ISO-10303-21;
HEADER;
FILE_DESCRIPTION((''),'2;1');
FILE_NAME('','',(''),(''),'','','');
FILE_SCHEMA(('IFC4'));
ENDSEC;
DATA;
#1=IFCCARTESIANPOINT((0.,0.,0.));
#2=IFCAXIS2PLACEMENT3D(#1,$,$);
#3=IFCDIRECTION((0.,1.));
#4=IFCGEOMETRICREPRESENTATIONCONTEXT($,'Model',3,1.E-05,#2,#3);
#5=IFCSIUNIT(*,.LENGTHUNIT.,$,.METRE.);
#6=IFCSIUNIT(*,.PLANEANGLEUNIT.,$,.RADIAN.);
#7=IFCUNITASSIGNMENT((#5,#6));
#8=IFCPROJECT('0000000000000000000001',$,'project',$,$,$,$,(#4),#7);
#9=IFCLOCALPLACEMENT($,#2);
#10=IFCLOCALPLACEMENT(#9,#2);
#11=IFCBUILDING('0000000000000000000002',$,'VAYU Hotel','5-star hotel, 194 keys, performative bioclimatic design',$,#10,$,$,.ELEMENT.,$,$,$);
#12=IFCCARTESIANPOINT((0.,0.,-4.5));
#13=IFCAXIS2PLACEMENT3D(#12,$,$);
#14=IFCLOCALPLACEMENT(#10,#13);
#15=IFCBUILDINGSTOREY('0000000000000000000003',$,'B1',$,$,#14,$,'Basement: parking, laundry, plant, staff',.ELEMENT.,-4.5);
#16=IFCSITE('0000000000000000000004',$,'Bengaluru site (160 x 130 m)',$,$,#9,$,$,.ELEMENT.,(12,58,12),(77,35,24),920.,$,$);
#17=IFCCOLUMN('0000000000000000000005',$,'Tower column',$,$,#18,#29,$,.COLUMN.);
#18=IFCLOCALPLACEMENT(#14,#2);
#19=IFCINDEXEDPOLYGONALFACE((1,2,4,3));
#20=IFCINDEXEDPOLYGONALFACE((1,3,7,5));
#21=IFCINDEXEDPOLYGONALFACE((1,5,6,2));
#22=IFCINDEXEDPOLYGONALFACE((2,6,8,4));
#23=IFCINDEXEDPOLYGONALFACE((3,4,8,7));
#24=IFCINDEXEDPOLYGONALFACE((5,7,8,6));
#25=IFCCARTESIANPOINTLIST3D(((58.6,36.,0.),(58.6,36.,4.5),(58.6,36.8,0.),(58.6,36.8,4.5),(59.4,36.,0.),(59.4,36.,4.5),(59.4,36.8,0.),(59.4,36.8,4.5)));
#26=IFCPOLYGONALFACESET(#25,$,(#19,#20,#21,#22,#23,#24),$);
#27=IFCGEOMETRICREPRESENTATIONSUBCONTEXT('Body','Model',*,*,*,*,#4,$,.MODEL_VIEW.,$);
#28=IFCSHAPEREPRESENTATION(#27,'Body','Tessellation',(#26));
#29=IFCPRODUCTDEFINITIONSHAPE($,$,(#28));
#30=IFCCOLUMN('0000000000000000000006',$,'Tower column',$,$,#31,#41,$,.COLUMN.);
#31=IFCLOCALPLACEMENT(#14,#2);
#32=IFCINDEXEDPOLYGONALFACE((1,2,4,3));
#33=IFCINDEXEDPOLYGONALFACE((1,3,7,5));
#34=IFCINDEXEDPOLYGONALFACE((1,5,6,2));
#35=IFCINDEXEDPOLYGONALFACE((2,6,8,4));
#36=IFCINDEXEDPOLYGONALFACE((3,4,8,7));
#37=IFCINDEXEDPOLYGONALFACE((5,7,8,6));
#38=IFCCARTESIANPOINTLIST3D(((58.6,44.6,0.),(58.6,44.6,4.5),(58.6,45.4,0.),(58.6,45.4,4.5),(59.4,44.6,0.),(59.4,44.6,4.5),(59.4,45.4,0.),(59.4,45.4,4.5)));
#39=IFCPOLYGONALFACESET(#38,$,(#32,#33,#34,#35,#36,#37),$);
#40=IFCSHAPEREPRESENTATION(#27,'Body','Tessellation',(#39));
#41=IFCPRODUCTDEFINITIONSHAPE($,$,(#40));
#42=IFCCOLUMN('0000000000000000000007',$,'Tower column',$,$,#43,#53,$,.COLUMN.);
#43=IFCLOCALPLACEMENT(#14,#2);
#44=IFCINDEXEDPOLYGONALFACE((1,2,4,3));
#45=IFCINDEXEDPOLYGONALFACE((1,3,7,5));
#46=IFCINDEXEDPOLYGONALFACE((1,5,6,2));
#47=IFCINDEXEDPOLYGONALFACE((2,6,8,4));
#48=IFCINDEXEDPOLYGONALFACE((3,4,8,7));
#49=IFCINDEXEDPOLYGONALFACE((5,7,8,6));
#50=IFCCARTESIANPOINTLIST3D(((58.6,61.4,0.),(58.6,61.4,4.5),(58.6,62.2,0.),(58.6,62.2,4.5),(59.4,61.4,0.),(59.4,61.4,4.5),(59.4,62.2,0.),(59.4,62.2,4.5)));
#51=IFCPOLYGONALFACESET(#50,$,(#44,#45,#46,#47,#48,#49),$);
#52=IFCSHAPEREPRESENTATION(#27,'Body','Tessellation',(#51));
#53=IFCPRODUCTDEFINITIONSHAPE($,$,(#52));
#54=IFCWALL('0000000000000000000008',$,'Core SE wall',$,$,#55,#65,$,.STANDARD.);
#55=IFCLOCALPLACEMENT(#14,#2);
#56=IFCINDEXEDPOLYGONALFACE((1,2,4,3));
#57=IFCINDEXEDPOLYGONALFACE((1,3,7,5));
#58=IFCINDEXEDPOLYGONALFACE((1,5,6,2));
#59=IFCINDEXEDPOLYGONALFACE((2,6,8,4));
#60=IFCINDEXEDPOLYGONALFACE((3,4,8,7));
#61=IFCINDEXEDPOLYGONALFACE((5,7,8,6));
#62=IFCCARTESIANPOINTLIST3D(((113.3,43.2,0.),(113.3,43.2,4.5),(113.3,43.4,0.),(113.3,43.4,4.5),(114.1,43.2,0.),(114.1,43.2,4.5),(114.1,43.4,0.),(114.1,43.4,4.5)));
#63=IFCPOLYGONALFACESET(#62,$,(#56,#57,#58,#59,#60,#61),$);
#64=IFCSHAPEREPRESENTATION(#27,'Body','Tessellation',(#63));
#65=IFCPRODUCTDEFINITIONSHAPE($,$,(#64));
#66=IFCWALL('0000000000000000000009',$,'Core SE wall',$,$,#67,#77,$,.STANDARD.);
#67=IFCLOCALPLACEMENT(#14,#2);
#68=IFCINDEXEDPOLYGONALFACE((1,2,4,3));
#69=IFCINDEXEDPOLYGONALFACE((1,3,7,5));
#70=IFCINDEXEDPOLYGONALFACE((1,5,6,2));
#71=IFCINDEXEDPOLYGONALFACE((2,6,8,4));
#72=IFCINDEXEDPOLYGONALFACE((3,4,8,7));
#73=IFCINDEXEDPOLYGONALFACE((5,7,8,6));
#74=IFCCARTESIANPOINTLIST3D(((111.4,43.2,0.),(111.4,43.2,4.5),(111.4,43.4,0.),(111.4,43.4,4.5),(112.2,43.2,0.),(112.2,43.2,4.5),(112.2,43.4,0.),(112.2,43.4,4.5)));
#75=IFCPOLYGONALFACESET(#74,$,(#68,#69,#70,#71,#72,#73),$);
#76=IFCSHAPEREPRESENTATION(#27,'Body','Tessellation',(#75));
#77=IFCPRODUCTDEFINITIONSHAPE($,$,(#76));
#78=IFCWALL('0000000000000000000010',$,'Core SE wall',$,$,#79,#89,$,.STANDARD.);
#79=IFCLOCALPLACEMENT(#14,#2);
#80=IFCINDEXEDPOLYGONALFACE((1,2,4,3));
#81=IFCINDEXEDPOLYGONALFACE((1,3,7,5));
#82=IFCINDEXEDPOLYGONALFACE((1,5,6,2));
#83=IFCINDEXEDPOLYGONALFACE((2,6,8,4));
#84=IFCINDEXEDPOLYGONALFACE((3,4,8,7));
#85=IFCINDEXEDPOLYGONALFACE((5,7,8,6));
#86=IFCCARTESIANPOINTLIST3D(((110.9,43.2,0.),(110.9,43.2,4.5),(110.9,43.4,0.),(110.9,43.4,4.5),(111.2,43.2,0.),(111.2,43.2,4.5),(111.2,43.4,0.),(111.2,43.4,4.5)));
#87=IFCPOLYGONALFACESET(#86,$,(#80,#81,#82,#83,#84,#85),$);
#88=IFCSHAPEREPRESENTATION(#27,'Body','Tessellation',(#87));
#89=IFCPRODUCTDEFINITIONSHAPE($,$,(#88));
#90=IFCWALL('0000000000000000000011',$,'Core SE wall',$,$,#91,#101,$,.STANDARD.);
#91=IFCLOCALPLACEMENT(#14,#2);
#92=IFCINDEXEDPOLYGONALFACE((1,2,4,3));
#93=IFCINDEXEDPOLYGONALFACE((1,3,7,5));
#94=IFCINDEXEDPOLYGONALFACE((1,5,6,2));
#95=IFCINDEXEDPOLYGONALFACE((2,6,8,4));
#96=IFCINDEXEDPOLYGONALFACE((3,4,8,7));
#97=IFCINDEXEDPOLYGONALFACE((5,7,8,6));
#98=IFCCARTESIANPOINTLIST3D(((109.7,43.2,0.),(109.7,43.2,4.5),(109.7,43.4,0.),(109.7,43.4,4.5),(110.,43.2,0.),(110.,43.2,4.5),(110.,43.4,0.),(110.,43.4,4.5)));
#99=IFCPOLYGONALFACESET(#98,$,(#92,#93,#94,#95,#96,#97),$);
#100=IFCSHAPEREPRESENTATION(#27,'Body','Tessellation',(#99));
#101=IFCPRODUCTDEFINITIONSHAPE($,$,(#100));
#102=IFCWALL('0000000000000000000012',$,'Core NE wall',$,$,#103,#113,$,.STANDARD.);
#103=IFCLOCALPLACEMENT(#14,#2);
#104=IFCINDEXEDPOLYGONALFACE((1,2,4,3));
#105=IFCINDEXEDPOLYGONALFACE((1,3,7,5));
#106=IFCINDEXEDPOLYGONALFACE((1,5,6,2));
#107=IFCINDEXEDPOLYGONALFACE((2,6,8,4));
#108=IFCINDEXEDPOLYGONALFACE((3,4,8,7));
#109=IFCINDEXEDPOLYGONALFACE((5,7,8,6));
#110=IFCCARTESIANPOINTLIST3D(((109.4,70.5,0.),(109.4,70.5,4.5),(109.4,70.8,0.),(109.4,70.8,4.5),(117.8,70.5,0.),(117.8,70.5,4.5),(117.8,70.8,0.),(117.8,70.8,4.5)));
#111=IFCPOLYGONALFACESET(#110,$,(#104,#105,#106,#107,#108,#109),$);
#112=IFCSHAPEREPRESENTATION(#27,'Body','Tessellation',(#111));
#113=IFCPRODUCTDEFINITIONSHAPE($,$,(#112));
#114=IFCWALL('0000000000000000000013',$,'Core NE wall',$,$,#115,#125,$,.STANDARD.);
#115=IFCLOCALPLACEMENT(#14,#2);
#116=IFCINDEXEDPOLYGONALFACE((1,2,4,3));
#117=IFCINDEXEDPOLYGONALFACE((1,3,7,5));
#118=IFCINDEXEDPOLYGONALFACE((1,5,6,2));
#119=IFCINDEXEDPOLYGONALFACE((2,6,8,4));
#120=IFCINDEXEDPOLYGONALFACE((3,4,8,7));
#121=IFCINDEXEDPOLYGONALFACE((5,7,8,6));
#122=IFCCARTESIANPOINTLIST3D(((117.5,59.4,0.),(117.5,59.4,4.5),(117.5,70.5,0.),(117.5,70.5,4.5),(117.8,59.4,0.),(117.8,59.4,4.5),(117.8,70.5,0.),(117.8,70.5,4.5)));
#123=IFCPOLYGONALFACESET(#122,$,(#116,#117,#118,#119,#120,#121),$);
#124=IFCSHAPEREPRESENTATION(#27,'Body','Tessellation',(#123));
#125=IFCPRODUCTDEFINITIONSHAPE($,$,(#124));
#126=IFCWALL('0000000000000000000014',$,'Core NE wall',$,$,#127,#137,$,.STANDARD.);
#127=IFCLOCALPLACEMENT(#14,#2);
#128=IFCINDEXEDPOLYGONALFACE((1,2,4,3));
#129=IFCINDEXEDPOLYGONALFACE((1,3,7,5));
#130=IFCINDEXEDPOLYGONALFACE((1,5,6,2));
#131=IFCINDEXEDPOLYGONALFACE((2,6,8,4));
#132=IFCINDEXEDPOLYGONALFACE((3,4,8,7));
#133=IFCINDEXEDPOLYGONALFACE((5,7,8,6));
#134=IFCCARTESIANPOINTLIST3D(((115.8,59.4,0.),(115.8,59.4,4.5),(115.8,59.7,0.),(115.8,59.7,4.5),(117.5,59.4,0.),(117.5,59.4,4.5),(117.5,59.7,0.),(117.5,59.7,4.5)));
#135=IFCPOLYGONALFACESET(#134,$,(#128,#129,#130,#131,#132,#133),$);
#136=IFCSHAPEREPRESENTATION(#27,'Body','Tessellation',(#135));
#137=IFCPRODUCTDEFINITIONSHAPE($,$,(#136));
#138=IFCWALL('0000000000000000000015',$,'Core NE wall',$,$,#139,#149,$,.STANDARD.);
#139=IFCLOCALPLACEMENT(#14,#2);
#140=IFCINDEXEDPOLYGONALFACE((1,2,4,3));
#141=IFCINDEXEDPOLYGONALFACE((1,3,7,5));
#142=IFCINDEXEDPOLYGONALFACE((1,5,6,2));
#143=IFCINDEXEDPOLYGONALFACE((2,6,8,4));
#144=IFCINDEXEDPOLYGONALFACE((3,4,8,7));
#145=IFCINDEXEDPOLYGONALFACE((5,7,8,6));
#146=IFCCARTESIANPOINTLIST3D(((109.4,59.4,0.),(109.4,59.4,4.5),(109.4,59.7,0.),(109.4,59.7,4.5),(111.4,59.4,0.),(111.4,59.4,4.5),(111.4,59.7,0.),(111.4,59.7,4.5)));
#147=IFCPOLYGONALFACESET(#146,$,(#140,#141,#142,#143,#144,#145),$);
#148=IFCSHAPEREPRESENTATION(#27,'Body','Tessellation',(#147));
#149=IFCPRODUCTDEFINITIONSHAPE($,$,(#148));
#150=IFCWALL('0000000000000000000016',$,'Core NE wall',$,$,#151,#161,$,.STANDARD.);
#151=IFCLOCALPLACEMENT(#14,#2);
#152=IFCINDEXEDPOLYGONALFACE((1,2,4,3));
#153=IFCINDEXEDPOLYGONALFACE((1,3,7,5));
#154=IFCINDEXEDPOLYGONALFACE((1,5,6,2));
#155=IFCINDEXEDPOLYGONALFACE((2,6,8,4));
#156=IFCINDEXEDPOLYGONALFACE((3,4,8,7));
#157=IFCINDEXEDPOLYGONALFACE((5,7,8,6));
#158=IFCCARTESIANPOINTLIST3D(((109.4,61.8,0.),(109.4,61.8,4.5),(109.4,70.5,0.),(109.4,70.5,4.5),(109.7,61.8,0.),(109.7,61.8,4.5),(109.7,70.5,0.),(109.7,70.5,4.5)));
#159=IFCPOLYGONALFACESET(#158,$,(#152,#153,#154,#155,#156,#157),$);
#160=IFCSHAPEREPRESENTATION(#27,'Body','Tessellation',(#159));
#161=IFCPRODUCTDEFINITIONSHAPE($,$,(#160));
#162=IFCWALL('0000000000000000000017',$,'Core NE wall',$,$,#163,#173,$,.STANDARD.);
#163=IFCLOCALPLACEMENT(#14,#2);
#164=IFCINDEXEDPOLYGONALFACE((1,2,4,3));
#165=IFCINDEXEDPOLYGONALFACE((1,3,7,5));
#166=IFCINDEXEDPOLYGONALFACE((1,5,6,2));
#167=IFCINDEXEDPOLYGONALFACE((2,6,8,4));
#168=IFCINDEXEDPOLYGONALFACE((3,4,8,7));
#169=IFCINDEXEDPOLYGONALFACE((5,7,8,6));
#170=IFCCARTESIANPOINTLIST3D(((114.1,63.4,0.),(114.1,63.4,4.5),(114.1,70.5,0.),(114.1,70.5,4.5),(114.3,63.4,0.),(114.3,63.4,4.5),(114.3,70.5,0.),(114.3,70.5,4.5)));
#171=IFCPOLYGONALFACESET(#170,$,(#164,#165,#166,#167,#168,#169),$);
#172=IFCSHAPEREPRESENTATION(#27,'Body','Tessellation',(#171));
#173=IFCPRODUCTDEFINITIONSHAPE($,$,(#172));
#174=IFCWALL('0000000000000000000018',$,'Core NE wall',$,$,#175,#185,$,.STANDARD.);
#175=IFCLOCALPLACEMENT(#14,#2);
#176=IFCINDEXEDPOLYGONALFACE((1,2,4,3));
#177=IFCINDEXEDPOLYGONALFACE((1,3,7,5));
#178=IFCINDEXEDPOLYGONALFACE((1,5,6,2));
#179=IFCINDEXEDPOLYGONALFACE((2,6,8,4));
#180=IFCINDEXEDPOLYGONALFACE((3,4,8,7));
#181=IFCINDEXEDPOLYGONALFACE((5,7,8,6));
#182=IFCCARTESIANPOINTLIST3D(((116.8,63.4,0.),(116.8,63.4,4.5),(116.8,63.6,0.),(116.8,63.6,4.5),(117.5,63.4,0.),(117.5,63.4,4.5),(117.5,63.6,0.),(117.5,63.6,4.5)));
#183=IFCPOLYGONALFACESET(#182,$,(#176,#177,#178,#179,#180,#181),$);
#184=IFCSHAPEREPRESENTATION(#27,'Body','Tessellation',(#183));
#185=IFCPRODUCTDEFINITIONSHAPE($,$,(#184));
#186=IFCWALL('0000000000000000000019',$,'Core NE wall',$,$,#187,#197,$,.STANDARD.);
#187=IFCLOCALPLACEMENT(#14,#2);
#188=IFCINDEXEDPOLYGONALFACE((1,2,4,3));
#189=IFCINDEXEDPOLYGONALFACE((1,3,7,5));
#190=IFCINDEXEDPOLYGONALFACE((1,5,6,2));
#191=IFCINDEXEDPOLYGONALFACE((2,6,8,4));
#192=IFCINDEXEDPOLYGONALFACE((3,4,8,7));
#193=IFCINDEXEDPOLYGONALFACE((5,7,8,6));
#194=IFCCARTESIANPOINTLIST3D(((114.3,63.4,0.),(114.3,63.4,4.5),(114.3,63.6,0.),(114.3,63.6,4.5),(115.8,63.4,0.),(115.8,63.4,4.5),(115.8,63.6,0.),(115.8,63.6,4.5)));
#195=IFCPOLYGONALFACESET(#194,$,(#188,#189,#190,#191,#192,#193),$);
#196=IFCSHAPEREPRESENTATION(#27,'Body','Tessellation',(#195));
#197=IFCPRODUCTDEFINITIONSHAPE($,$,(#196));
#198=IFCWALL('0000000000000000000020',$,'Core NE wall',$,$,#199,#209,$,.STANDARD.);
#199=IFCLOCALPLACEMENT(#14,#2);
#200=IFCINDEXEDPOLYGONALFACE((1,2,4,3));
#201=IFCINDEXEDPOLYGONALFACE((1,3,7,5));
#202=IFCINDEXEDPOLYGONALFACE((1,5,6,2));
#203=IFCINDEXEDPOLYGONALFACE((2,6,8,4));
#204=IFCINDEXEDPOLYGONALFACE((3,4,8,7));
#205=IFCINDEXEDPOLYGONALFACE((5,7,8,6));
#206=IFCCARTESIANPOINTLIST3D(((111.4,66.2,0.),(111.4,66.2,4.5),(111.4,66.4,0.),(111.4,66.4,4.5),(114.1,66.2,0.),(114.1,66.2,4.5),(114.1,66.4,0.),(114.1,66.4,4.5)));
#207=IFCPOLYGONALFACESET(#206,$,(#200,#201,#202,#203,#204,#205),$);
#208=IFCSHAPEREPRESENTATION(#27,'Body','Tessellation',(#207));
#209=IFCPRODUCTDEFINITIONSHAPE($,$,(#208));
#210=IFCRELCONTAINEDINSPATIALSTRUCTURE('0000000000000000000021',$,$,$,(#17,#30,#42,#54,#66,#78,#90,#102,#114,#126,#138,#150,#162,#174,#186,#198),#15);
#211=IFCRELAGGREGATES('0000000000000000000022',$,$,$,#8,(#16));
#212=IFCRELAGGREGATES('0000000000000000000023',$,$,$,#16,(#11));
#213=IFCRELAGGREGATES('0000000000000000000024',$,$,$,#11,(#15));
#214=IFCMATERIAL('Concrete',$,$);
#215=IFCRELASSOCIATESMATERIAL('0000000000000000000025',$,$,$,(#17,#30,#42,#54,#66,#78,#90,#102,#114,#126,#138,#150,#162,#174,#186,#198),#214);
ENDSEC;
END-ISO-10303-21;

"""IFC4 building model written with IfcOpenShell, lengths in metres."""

from ifc_helpers import new_model, si_unit, direction, frame, origin, place, context, subcontext, project, spatial, polyline, outline, extrude, material, element, save


model = new_model("IFC4")

# Units and contexts
model_context = context("Model", 3, precision=1e-05, world=origin(), true_north=direction((0.0, 1.0)))
body_context = subcontext(model_context, "Body", "Model", "MODEL_VIEW")
ifc_project = project(units=[si_unit("LENGTHUNIT", "METRE"), si_unit("PLANEANGLEUNIT", "RADIAN")], contexts=[model_context])

# Site, building, storey
site_placement = place(None, origin())
site = spatial("IfcSite", under=ifc_project, at=site_placement, Name="Bengaluru site (160 x 130 m)", CompositionType="ELEMENT", RefLatitude=(12, 58, 12), RefLongitude=(77, 35, 24), RefElevation=920.0)
building_placement = place(site_placement, origin())
building = spatial("IfcBuilding", under=site, at=building_placement, Name="VAYU Hotel", Description="5-star hotel, 194 keys, performative bioclimatic design", CompositionType="ELEMENT")
storey_placement = place(building_placement, frame((0.0, 0.0, -4.5)))
storey = spatial("IfcBuildingStorey", under=building, at=storey_placement, Name="B1", LongName="Basement: parking, laundry, plant, staff", CompositionType="ELEMENT", Elevation=-4.5)

# Columns
ifc_material = material(Name="Concrete")
column_1_placement = place(storey_placement, origin())
element("IfcColumn", 1, at=column_1_placement, inside=storey, material=ifc_material, Name="Tower column", PredefinedType="COLUMN", context=body_context, shape_type="SweptSolid", body=[
    extrude(outline(polyline([(58.6, 36.0), (59.4, 36.0), (59.4, 36.8), (58.6, 36.8), (58.6, 36.0)])), origin(), (0.0, 0.0, 1.0), 4.5),
])
column_2_placement = place(storey_placement, origin())
element("IfcColumn", 2, at=column_2_placement, inside=storey, material=ifc_material, Name="Tower column", PredefinedType="COLUMN", context=body_context, shape_type="SweptSolid", body=[
    extrude(outline(polyline([(58.6, 44.6), (59.4, 44.6), (59.4, 45.4), (58.6, 45.4), (58.6, 44.6)])), origin(), (0.0, 0.0, 1.0), 4.5),
])
column_3_placement = place(storey_placement, origin())
element("IfcColumn", 3, at=column_3_placement, inside=storey, material=ifc_material, Name="Tower column", PredefinedType="COLUMN", context=body_context, shape_type="SweptSolid", body=[
    extrude(outline(polyline([(58.6, 61.4), (59.4, 61.4), (59.4, 62.2), (58.6, 62.2), (58.6, 61.4)])), origin(), (0.0, 0.0, 1.0), 4.5),
])

# Walls
wall_1_placement = place(storey_placement, origin())
element("IfcWall", 4, at=wall_1_placement, inside=storey, material=ifc_material, Name="Core SE wall", PredefinedType="STANDARD", context=body_context, shape_type="SweptSolid", body=[
    extrude(outline(polyline([(113.3, 43.4), (114.1, 43.4), (114.1, 43.2), (113.3, 43.2), (113.3, 43.4)])), origin(), (0.0, 0.0, 1.0), 4.5),
])
wall_2_placement = place(storey_placement, origin())
element("IfcWall", 5, at=wall_2_placement, inside=storey, material=ifc_material, Name="Core SE wall", PredefinedType="STANDARD", context=body_context, shape_type="SweptSolid", body=[
    extrude(outline(polyline([(111.4, 43.4), (112.2, 43.4), (112.2, 43.2), (111.4, 43.2), (111.4, 43.4)])), origin(), (0.0, 0.0, 1.0), 4.5),
])
wall_3_placement = place(storey_placement, origin())
element("IfcWall", 6, at=wall_3_placement, inside=storey, material=ifc_material, Name="Core SE wall", PredefinedType="STANDARD", context=body_context, shape_type="SweptSolid", body=[
    extrude(outline(polyline([(110.9, 43.4), (111.2, 43.4), (111.2, 43.2), (110.9, 43.2), (110.9, 43.4)])), origin(), (0.0, 0.0, 1.0), 4.5),
])
wall_4_placement = place(storey_placement, origin())
element("IfcWall", 7, at=wall_4_placement, inside=storey, material=ifc_material, Name="Core SE wall", PredefinedType="STANDARD", context=body_context, shape_type="SweptSolid", body=[
    extrude(outline(polyline([(109.7, 43.4), (110.0, 43.4), (110.0, 43.2), (109.7, 43.2), (109.7, 43.4)])), origin(), (0.0, 0.0, 1.0), 4.5),
])
wall_5_placement = place(storey_placement, origin())
element("IfcWall", 8, at=wall_5_placement, inside=storey, material=ifc_material, Name="Core NE wall", PredefinedType="STANDARD", context=body_context, shape_type="SweptSolid", body=[
    extrude(outline(polyline([(109.4, 70.8), (117.8, 70.8), (117.8, 70.5), (109.4, 70.5), (109.4, 70.8)])), origin(), (0.0, 0.0, 1.0), 4.5),
])
wall_6_placement = place(storey_placement, origin())
element("IfcWall", 9, at=wall_6_placement, inside=storey, material=ifc_material, Name="Core NE wall", PredefinedType="STANDARD", context=body_context, shape_type="SweptSolid", body=[
    extrude(outline(polyline([(117.5, 59.4), (117.5, 70.5), (117.8, 70.5), (117.8, 59.4), (117.5, 59.4)])), origin(), (0.0, 0.0, 1.0), 4.5),
])
wall_7_placement = place(storey_placement, origin())
element("IfcWall", 10, at=wall_7_placement, inside=storey, material=ifc_material, Name="Core NE wall", PredefinedType="STANDARD", context=body_context, shape_type="SweptSolid", body=[
    extrude(outline(polyline([(115.8, 59.7), (117.5, 59.7), (117.5, 59.4), (115.8, 59.4), (115.8, 59.7)])), origin(), (0.0, 0.0, 1.0), 4.5),
])
wall_8_placement = place(storey_placement, origin())
element("IfcWall", 11, at=wall_8_placement, inside=storey, material=ifc_material, Name="Core NE wall", PredefinedType="STANDARD", context=body_context, shape_type="SweptSolid", body=[
    extrude(outline(polyline([(109.4, 59.7), (111.4, 59.7), (111.4, 59.4), (109.4, 59.4), (109.4, 59.7)])), origin(), (0.0, 0.0, 1.0), 4.5),
])
wall_9_placement = place(storey_placement, origin())
element("IfcWall", 12, at=wall_9_placement, inside=storey, material=ifc_material, Name="Core NE wall", PredefinedType="STANDARD", context=body_context, shape_type="SweptSolid", body=[
    extrude(outline(polyline([(109.4, 61.8), (109.4, 70.5), (109.7, 70.5), (109.7, 61.8), (109.4, 61.8)])), origin(), (0.0, 0.0, 1.0), 4.5),
])
wall_10_placement = place(storey_placement, origin())
element("IfcWall", 13, at=wall_10_placement, inside=storey, material=ifc_material, Name="Core NE wall", PredefinedType="STANDARD", context=body_context, shape_type="SweptSolid", body=[
    extrude(outline(polyline([(114.1, 63.4), (114.1, 70.5), (114.3, 70.5), (114.3, 63.4), (114.1, 63.4)])), origin(), (0.0, 0.0, 1.0), 4.5),
])
wall_11_placement = place(storey_placement, origin())
element("IfcWall", 14, at=wall_11_placement, inside=storey, material=ifc_material, Name="Core NE wall", PredefinedType="STANDARD", context=body_context, shape_type="SweptSolid", body=[
    extrude(outline(polyline([(116.8, 63.6), (117.5, 63.6), (117.5, 63.4), (116.8, 63.4), (116.8, 63.6)])), origin(), (0.0, 0.0, 1.0), 4.5),
])
wall_12_placement = place(storey_placement, origin())
element("IfcWall", 15, at=wall_12_placement, inside=storey, material=ifc_material, Name="Core NE wall", PredefinedType="STANDARD", context=body_context, shape_type="SweptSolid", body=[
    extrude(outline(polyline([(114.3, 63.6), (115.8, 63.6), (115.8, 63.4), (114.3, 63.4), (114.3, 63.6)])), origin(), (0.0, 0.0, 1.0), 4.5),
])
wall_13_placement = place(storey_placement, origin())
element("IfcWall", 16, at=wall_13_placement, inside=storey, material=ifc_material, Name="Core NE wall", PredefinedType="STANDARD", context=body_context, shape_type="SweptSolid", body=[
    extrude(outline(polyline([(111.4, 66.4), (114.1, 66.4), (114.1, 66.2), (111.4, 66.2), (111.4, 66.4)])), origin(), (0.0, 0.0, 1.0), 4.5),
])

save(model, "model.ifc")
